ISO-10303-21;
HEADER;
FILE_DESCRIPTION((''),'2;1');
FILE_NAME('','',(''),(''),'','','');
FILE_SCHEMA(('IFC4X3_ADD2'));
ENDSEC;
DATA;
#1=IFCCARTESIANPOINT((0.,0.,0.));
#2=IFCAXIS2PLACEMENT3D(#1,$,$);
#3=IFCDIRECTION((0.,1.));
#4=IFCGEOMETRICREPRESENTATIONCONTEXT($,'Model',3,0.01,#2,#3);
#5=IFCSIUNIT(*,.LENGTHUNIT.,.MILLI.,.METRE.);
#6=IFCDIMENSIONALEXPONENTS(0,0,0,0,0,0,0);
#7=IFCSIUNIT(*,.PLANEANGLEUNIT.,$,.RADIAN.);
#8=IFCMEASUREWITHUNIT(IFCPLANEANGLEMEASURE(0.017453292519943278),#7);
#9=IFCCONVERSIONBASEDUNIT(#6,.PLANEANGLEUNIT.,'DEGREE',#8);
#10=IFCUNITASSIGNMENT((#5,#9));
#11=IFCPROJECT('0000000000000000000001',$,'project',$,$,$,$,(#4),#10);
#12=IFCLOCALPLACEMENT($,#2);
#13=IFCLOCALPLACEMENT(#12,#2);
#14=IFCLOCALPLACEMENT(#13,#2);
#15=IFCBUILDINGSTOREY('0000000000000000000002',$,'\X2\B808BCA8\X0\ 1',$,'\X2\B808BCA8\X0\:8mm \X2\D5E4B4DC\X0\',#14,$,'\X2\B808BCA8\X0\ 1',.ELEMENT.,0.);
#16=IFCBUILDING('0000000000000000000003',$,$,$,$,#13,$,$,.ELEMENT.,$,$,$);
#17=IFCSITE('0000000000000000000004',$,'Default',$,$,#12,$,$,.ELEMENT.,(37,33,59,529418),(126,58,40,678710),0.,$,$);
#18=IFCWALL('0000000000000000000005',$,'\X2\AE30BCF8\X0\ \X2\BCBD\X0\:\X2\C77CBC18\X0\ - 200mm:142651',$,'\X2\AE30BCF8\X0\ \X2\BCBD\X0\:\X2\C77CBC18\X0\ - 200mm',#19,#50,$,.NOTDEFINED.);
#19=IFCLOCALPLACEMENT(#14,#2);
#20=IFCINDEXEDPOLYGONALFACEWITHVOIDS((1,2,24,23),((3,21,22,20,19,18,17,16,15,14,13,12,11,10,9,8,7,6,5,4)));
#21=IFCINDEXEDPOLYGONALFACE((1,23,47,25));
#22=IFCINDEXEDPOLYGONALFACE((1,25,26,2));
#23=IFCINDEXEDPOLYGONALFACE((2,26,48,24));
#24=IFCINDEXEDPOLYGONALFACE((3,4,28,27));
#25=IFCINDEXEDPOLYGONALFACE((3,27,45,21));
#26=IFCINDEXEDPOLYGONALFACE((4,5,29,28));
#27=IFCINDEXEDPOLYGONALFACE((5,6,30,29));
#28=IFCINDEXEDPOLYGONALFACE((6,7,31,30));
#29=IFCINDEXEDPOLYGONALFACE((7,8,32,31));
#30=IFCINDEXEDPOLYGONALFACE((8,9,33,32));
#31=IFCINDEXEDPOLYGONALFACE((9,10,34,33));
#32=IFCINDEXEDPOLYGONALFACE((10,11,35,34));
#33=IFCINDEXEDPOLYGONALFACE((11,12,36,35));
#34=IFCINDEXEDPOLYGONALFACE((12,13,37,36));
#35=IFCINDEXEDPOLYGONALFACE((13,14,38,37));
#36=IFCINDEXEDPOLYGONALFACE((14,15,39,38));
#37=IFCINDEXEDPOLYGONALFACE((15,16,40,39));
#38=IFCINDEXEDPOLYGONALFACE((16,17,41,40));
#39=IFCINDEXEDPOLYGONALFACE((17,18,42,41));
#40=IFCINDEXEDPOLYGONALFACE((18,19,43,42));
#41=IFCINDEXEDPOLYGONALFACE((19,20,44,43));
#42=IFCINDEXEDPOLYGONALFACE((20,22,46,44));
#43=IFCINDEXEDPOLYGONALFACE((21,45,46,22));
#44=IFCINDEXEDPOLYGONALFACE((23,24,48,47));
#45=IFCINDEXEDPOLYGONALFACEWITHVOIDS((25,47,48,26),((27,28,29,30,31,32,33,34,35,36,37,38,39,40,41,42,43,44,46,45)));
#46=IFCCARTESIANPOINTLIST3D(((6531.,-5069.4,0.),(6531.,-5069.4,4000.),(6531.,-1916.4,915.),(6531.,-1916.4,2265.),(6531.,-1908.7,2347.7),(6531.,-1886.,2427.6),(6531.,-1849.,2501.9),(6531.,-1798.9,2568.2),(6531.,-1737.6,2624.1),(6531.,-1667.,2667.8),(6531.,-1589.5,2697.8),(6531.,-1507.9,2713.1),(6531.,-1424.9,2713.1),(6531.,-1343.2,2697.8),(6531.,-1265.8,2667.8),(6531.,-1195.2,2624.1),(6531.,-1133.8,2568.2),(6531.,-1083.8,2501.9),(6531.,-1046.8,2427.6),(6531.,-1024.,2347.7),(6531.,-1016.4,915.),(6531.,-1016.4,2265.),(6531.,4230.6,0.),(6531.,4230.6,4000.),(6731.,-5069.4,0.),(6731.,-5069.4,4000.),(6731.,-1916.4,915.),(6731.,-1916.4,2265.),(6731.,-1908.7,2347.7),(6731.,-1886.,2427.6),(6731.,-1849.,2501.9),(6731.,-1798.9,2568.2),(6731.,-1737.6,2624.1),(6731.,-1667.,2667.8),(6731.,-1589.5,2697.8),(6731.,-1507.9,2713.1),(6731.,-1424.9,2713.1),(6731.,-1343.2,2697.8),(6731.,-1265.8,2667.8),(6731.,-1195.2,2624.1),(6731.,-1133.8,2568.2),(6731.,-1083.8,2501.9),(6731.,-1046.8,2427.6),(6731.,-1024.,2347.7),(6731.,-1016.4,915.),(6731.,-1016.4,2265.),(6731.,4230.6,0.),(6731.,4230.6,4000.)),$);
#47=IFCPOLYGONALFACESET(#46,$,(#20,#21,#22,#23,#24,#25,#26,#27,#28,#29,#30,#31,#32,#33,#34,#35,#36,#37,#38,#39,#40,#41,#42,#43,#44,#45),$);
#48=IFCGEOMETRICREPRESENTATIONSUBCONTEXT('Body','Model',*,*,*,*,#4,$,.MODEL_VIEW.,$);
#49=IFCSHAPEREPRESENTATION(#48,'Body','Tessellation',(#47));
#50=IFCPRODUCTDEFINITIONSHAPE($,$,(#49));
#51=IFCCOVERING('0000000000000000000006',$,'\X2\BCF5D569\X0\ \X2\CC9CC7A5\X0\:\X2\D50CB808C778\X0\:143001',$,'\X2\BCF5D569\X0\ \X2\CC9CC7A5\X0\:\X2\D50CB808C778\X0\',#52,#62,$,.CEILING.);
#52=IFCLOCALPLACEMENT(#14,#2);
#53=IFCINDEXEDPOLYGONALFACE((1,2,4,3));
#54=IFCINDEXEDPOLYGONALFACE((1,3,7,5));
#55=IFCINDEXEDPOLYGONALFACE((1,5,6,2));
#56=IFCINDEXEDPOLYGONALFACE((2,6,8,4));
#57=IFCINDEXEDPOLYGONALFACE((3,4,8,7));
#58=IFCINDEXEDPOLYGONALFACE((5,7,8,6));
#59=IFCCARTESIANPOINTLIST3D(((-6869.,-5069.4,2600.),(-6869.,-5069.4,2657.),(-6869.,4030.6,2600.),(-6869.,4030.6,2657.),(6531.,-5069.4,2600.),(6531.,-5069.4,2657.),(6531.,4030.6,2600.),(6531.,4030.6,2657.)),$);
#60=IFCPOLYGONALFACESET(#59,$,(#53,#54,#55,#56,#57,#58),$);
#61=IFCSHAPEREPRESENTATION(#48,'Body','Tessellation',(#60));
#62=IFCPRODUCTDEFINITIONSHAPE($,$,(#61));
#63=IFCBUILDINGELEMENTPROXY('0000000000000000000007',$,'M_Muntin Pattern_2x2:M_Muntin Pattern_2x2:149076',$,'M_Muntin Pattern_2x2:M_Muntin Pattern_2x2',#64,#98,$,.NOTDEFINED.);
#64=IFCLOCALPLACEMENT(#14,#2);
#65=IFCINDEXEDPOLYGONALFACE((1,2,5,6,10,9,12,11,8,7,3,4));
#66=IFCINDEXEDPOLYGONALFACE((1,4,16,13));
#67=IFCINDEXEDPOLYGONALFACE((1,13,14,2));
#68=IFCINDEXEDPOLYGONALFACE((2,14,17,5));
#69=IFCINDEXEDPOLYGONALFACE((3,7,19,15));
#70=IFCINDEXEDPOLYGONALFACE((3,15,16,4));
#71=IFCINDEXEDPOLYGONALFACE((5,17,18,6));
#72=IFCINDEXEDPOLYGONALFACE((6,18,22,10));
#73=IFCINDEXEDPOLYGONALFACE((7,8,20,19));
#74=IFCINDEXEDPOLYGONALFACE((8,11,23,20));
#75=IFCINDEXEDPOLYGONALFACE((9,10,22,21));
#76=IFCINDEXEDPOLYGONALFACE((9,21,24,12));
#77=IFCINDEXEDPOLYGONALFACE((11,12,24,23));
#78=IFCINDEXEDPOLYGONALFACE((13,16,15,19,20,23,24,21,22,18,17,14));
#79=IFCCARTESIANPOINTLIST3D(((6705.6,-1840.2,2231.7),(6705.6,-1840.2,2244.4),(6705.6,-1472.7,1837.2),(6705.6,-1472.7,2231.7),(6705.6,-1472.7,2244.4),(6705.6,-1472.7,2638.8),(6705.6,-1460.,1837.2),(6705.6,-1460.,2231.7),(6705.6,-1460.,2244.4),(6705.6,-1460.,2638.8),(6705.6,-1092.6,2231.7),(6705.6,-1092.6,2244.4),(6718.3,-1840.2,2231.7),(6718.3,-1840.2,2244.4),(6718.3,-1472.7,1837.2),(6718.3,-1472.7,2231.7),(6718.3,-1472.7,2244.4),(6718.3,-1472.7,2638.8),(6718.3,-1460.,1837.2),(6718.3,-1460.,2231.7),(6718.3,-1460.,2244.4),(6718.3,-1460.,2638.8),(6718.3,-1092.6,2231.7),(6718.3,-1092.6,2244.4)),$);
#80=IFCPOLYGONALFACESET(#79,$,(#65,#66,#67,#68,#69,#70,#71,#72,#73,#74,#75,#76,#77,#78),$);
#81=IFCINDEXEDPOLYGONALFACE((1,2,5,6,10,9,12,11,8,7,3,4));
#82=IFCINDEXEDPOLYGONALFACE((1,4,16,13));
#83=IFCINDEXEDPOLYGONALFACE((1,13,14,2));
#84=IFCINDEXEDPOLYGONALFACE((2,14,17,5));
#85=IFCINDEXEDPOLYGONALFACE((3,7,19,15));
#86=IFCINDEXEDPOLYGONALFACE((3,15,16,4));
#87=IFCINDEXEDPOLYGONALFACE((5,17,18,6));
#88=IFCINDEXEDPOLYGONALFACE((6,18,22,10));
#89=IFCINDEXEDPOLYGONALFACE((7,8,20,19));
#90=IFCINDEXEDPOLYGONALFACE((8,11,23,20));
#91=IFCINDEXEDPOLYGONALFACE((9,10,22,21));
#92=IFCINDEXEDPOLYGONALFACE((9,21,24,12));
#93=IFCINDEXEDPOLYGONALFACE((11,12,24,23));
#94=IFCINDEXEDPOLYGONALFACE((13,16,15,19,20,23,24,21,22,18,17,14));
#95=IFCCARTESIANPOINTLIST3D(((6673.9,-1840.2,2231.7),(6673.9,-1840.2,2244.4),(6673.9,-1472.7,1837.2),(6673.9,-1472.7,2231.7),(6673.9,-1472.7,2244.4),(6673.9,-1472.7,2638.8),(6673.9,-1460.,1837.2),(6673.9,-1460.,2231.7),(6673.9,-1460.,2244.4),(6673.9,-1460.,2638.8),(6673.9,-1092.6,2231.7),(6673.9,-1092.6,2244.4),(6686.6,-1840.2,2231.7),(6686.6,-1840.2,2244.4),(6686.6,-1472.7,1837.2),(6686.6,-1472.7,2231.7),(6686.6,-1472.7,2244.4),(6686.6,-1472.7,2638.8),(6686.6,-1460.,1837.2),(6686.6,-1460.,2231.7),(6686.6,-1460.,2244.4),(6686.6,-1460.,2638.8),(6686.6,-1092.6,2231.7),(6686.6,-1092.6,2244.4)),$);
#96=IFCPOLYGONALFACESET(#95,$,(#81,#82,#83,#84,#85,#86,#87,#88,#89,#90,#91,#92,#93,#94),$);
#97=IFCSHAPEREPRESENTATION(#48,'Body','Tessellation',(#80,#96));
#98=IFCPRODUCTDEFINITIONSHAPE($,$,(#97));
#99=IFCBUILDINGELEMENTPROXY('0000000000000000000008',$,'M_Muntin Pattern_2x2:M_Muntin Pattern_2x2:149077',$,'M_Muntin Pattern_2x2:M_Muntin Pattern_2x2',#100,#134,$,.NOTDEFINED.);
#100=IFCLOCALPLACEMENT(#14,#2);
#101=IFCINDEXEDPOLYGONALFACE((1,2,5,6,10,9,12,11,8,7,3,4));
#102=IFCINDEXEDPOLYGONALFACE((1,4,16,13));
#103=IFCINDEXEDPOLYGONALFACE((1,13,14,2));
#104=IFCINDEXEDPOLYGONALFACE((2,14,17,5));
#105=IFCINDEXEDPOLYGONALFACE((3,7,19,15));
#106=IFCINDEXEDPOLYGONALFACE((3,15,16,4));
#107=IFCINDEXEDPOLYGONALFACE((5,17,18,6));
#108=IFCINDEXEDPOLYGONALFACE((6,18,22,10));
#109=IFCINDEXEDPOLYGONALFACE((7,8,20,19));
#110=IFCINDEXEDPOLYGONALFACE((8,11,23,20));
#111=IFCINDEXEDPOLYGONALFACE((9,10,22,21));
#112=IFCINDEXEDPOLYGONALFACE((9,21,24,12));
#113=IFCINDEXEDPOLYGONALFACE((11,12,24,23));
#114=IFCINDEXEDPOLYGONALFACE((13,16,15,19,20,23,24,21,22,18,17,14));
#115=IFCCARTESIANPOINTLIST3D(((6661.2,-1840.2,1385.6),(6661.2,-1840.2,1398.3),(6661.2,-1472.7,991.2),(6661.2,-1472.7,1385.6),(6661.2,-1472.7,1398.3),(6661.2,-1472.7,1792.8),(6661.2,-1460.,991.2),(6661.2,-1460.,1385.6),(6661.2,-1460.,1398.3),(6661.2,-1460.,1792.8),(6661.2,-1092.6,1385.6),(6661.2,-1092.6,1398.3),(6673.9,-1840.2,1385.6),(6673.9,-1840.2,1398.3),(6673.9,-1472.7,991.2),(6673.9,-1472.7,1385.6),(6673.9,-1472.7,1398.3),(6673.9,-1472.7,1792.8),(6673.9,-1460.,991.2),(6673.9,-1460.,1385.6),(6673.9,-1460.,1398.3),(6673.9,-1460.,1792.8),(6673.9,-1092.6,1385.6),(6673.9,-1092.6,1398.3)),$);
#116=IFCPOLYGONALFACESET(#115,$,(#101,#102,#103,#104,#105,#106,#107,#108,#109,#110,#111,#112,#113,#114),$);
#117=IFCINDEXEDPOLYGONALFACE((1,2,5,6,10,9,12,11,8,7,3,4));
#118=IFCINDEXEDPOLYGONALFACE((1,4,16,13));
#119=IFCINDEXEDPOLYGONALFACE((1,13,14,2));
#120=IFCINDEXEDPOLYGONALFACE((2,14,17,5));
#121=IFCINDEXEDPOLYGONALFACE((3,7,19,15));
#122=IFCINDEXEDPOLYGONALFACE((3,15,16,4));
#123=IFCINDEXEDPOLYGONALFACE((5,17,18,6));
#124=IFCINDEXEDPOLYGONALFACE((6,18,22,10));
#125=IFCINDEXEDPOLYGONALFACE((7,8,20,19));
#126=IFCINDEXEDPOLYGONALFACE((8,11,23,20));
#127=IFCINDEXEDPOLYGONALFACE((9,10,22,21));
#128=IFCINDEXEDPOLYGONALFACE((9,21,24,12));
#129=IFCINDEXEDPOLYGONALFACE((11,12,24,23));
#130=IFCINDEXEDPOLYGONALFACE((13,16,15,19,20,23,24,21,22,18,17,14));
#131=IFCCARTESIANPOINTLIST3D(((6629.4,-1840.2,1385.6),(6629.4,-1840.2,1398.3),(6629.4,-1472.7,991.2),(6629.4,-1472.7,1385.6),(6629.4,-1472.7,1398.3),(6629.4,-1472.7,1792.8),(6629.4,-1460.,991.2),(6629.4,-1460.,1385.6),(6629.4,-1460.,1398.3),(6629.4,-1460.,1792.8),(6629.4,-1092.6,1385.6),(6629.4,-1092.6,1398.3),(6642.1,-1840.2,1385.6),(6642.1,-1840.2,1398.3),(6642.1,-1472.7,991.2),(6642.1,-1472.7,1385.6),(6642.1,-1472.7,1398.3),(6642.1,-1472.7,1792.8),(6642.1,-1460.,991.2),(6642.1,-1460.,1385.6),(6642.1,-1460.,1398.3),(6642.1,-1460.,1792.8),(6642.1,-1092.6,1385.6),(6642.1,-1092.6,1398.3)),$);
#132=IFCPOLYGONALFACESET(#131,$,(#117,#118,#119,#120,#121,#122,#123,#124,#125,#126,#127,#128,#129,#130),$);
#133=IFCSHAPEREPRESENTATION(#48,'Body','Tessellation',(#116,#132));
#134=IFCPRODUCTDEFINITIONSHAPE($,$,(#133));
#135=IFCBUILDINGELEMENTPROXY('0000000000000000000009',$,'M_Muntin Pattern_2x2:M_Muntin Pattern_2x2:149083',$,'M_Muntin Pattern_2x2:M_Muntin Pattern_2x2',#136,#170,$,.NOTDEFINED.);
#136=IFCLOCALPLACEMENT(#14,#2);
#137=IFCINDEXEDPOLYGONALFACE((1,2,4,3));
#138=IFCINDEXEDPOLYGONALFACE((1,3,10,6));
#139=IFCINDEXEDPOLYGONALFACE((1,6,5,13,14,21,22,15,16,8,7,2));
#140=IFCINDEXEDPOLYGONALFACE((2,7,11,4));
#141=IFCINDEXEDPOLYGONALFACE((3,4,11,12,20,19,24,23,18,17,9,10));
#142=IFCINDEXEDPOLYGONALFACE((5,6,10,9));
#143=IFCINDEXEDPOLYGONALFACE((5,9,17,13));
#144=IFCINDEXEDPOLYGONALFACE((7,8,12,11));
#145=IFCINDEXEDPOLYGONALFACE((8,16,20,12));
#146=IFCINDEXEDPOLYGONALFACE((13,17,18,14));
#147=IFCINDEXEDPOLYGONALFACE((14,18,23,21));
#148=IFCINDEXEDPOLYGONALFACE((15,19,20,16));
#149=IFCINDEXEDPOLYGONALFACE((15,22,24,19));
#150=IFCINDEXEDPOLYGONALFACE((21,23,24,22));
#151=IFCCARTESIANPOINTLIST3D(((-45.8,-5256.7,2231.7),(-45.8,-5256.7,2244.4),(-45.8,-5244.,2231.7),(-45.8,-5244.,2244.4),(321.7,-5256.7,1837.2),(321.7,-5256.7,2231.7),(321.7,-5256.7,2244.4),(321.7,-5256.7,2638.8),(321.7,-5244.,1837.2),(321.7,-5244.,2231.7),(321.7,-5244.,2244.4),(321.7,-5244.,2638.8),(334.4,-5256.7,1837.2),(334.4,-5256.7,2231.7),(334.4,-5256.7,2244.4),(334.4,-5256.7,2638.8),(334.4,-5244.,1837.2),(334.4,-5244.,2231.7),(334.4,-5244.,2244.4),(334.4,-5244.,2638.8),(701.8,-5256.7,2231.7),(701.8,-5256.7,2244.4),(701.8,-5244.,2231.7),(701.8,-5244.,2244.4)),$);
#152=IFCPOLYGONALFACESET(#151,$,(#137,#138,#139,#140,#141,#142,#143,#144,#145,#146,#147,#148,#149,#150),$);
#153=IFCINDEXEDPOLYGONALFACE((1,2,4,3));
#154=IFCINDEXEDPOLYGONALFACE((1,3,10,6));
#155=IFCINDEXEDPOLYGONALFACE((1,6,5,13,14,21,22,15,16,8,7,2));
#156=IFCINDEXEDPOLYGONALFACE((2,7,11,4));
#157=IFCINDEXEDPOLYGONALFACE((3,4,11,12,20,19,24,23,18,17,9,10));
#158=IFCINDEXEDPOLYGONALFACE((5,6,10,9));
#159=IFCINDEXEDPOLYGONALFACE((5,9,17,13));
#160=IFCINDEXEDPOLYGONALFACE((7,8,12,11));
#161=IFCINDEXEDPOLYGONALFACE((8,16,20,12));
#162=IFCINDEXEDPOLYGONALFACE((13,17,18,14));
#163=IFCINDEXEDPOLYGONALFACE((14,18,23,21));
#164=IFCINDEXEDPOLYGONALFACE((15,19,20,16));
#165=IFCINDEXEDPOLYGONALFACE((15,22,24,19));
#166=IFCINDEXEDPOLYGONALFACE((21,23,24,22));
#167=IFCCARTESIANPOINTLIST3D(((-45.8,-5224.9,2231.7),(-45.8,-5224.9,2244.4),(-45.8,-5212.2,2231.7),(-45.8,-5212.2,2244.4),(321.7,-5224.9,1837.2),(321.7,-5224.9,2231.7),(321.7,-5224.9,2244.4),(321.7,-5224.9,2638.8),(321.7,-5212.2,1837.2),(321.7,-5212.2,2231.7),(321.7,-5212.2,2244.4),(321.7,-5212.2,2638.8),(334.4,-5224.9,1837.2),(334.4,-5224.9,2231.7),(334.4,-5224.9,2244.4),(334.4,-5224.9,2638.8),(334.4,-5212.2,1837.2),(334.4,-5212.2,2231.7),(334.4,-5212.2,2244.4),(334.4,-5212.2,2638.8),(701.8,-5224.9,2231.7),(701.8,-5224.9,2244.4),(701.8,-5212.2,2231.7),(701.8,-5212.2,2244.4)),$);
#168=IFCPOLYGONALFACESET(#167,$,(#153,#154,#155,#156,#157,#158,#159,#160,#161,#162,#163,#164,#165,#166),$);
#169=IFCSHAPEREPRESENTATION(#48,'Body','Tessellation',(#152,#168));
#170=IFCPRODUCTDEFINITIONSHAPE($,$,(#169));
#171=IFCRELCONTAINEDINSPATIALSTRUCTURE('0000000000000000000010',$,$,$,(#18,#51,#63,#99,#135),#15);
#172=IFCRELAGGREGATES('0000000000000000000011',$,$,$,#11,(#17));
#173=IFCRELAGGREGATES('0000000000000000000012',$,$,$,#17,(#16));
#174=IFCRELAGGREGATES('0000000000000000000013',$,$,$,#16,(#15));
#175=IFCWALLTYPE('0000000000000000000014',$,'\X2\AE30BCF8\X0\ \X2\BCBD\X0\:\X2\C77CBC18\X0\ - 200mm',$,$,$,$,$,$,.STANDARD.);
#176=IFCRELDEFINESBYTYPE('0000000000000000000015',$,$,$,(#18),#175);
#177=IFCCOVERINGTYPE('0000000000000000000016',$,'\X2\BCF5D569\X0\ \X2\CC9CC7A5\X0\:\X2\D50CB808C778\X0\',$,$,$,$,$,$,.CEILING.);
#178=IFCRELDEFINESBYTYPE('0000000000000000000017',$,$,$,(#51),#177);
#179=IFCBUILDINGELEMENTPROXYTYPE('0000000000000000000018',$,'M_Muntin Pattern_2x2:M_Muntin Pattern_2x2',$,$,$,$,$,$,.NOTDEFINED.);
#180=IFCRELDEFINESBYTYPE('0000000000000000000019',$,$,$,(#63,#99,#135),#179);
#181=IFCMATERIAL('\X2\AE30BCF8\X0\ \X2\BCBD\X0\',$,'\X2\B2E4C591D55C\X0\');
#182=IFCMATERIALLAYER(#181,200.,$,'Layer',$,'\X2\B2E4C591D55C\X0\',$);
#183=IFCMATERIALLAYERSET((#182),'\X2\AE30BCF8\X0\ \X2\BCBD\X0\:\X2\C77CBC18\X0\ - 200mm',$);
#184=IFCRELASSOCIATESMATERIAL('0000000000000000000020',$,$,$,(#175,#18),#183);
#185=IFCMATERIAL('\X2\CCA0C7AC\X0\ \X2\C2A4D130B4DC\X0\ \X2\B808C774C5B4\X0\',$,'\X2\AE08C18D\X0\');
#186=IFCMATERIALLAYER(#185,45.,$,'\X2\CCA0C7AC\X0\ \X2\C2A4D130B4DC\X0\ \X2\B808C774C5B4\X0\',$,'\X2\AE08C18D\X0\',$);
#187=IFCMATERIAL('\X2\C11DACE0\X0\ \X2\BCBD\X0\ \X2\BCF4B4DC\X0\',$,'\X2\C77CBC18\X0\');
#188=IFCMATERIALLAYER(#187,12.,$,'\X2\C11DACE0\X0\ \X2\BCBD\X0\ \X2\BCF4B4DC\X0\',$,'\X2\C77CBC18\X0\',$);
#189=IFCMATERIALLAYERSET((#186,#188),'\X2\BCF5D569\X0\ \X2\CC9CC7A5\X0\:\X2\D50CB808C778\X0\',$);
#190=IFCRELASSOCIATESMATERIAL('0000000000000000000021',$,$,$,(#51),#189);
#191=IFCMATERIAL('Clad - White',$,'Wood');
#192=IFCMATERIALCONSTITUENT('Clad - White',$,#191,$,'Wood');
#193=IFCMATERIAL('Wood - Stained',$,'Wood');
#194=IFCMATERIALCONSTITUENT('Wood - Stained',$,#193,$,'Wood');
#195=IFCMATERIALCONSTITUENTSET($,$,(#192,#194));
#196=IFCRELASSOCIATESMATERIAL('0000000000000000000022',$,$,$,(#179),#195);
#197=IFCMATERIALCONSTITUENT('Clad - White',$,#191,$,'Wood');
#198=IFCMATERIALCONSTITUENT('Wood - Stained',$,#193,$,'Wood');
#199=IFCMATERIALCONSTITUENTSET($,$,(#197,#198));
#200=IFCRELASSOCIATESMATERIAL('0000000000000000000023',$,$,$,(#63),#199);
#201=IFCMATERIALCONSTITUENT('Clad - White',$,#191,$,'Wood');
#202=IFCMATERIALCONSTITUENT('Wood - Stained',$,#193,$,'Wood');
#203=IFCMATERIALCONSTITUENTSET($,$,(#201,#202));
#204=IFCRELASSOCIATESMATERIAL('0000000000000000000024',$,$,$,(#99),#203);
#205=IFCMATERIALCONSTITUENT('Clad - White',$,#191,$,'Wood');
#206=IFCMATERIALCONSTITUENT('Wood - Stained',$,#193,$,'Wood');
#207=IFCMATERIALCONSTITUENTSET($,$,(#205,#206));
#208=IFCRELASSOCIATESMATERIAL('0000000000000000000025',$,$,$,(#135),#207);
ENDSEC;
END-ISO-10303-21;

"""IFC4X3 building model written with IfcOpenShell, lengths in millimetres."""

from ifc_helpers import new_model, entity, si_unit, converted_unit, direction, frame, frame_2d, origin, origin_2d_with_axis, place, context, subcontext, project, spatial, polyline, circle_curve, parameter, trimmed, segment, composite_curve, rectangle, outline, extrude, source, transform, mapped, material, layer, layer_set, layer_usage, constituent, constituent_set, type_object, type_shapes, element, save


model = new_model("IFC4X3")

# Units and contexts
model_context = context("Model", 3, precision=0.01, world=origin(), true_north=direction((0.0, 1.0)))
body_context = subcontext(model_context, "Body", "Model", "MODEL_VIEW")
ifc_project = project(units=[si_unit("LENGTHUNIT", "METRE", prefix="MILLI"), converted_unit("PLANEANGLEUNIT", "DEGREE", entity("IfcPlaneAngleMeasure", 0.017453292519943278), si_unit("PLANEANGLEUNIT", "RADIAN"), dimensions=[0, 0, 0, 0, 0, 0, 0])], contexts=[model_context])

# Site, building, storey
site_placement = place(None, origin())
site = spatial("IfcSite", under=ifc_project, at=site_placement, Name="Default", CompositionType="ELEMENT", RefLatitude=(37, 33, 59, 529418), RefLongitude=(126, 58, 40, 678710), RefElevation=0.0)
building_placement = place(site_placement, origin())
building = spatial("IfcBuilding", under=site, at=building_placement, CompositionType="ELEMENT")
storey_placement = place(building_placement, origin())
storey = spatial("IfcBuildingStorey", under=building, at=storey_placement, Name="레벨 1", ObjectType="레벨:8mm 헤드", LongName="레벨 1", CompositionType="ELEMENT", Elevation=0.0)

# Shared definitions
ifc_material_1 = material(Name="기본 벽", Category="다양한")
ifc_layer_1 = layer(ifc_material_1, 200.0, Name="Layer", Category="다양한")
ifc_layer_set_1 = layer_set([ifc_layer_1], Name="기본 벽:일반 - 200mm")
wall_type = type_object("IfcWallType", Name="기본 벽:일반 - 200mm", PredefinedType="STANDARD", material=ifc_layer_set_1)

# Wall, opening
wall_1_placement = place(storey_placement, frame((6631.0, 4230.6, 0.0), z_axis=(0.0, 0.0, 1.0), x_axis=(0.0, -1.0, 0.0)))
wall_1 = element("IfcWall", 1, at=wall_1_placement, inside=storey, type_object=wall_type, material=ifc_layer_set_1, Name="기본 벽:일반 - 200mm:142651", ObjectType="기본 벽:일반 - 200mm", PredefinedType="NOTDEFINED", context=body_context, shape_type="SweptSolid", body=[
    extrude(rectangle(XDim=9300.0, YDim=200.0, at=frame_2d((4650.0, 0.0), x_axis=(-1.0, 0.0))), origin(), (0.0, 0.0, 1.0), 4000.0),
])
opening_1_placement = place(wall_1_placement, frame((5247.0, -100.0, 915.0)))
element("IfcOpeningElement", 2, at=opening_1_placement, cuts=wall_1, PredefinedType="OPENING", context=body_context, shape_type="SweptSolid", body=[
    extrude(outline(composite_curve([segment(polyline([(1350.0, 900.0), (0.0, 900.0)]), True, "CONTINUOUS"), segment(polyline([(0.0, 900.0), (0.0, 0.0)]), True, "CONTINUOUS"), segment(polyline([(0.0, 0.0), (1350.0, 0.0)]), True, "CONTINUOUS"), segment(trimmed(circle_curve(frame_2d((1350.0, 450.0), x_axis=(0.0, 1.0)), 450.0), [parameter(180.0)], [parameter(0.0)], True, "PARAMETER"), True, "CONTINUOUS")], self_intersect=False)), frame((0.0, 0.0, 0.0), z_axis=(0.0, 1.0, 0.0), x_axis=(0.0, 0.0, 1.0)), (0.0, 0.0, 1.0), 200.0),
])

# Covering
ifc_material_2 = material(Name="철재 스터드 레이어", Category="금속")
ifc_layer_2 = layer(ifc_material_2, 45.0, Name="철재 스터드 레이어", Category="금속")
ifc_material_3 = material(Name="석고 벽 보드", Category="일반")
ifc_layer_3 = layer(ifc_material_3, 12.0, Name="석고 벽 보드", Category="일반")
ifc_layer_set_2 = layer_set([ifc_layer_2, ifc_layer_3], Name="복합 천장:플레인")
ifc_layer_usage_1 = layer_usage(ifc_layer_set_2, "AXIS3", "NEGATIVE", 57.0)
covering_type = type_object("IfcCoveringType", Name="복합 천장:플레인", PredefinedType="CEILING")
covering_placement = place(storey_placement, frame((-6869.0, -5069.4, 2600.0)))
element("IfcCovering", 3, at=covering_placement, inside=storey, type_object=covering_type, material=ifc_layer_usage_1, Name="복합 천장:플레인:143001", ObjectType="복합 천장:플레인", PredefinedType="CEILING", context=body_context, shape_type="SweptSolid", body=[
    extrude(rectangle(XDim=9100.0, YDim=13400.0, at=origin_2d_with_axis()), frame((6700.0, 4550.0, 0.0), z_axis=(0.0, 0.0, 1.0), x_axis=(0.0, -1.0, 0.0)), (0.0, 0.0, 1.0), 57.0),
])

# Building element proxies
ifc_material_4 = material(Name="Clad - White", Category="Wood")
ifc_constituent_1 = constituent(ifc_material_4, Name="Clad - White", Category="Wood")
ifc_material_5 = material(Name="Wood - Stained", Category="Wood")
ifc_constituent_2 = constituent(ifc_material_5, Name="Wood - Stained", Category="Wood")
ifc_constituent_set_1 = constituent_set(constituents=[ifc_constituent_1, ifc_constituent_2])
ifc_constituent_3 = constituent(ifc_material_4, Name="Clad - White", Category="Wood")
ifc_constituent_4 = constituent(ifc_material_5, Name="Wood - Stained", Category="Wood")
ifc_constituent_set_2 = constituent_set(constituents=[ifc_constituent_3, ifc_constituent_4])
building_element_proxy_type_1 = type_object("IfcBuildingElementProxyType", Name="M_Muntin Pattern_2x2:M_Muntin Pattern_2x2", PredefinedType="NOTDEFINED", material=ifc_constituent_set_2)
shared_shape_1 = source(origin(), body_context, "Body", "SweptSolid", [
    extrude(outline(polyline([(6.4, -6.4), (400.8, -6.4), (400.8, 6.3), (6.4, 6.3), (6.4, 373.8), (-6.3, 373.8), (-6.3, 6.3), (-400.8, 6.3), (-400.8, -6.4), (-6.3, -6.4), (-6.3, -373.8), (6.4, -373.8), (6.4, -6.4)])), frame((0.0, 9.5, 400.8), z_axis=(0.0, 1.0, 0.0), x_axis=(0.0, 0.0, 1.0)), (0.0, 0.0, 1.0), 12.7),
    extrude(outline(polyline([(6.4, -6.4), (400.8, -6.4), (400.8, 6.3), (6.4, 6.3), (6.4, 373.8), (-6.3, 373.8), (-6.3, 6.3), (-400.8, 6.3), (-400.8, -6.4), (-6.3, -6.4), (-6.3, -373.8), (6.4, -373.8), (6.4, -6.4)])), frame((0.0, -22.2, 400.8), z_axis=(0.0, 1.0, 0.0), x_axis=(0.0, 0.0, 1.0)), (0.0, 0.0, 1.0), 12.7),
])
type_shapes(building_element_proxy_type_1, [shared_shape_1])
proxy_1_placement = place(storey_placement, frame((6696.1, -1466.4, 1837.2), z_axis=(0.0, 0.0, 1.0), x_axis=(0.0, -1.0, 0.0)))
element("IfcBuildingElementProxy", 4, at=proxy_1_placement, inside=storey, type_object=building_element_proxy_type_1, material=ifc_constituent_set_1, Name="M_Muntin Pattern_2x2:M_Muntin Pattern_2x2:149076", ObjectType="M_Muntin Pattern_2x2:M_Muntin Pattern_2x2", PredefinedType="NOTDEFINED", context=body_context, shape_type="MappedRepresentation", body=[
    mapped(shared_shape_1, transform((0.0, 0.0, 0.0), scale=1.0)),
])
ifc_constituent_5 = constituent(ifc_material_4, Name="Clad - White", Category="Wood")
ifc_constituent_6 = constituent(ifc_material_5, Name="Wood - Stained", Category="Wood")
ifc_constituent_set_3 = constituent_set(constituents=[ifc_constituent_5, ifc_constituent_6])
proxy_2_placement = place(storey_placement, frame((6651.7, -1466.4, 991.2), z_axis=(0.0, 0.0, 1.0), x_axis=(0.0, -1.0, 0.0)))
element("IfcBuildingElementProxy", 5, at=proxy_2_placement, inside=storey, type_object=building_element_proxy_type_1, material=ifc_constituent_set_3, Name="M_Muntin Pattern_2x2:M_Muntin Pattern_2x2:149077", ObjectType="M_Muntin Pattern_2x2:M_Muntin Pattern_2x2", PredefinedType="NOTDEFINED", context=body_context, shape_type="MappedRepresentation", body=[
    mapped(shared_shape_1, transform((0.0, 0.0, 0.0), scale=1.0)),
])
ifc_constituent_7 = constituent(ifc_material_4, Name="Clad - White", Category="Wood")
ifc_constituent_8 = constituent(ifc_material_5, Name="Wood - Stained", Category="Wood")
ifc_constituent_set_4 = constituent_set(constituents=[ifc_constituent_7, ifc_constituent_8])
proxy_3_placement = place(storey_placement, frame((328.0, -5234.4, 1837.2), z_axis=(0.0, 0.0, 1.0), x_axis=(-1.0, 0.0, 0.0)))
element("IfcBuildingElementProxy", 6, at=proxy_3_placement, inside=storey, type_object=building_element_proxy_type_1, material=ifc_constituent_set_4, Name="M_Muntin Pattern_2x2:M_Muntin Pattern_2x2:149083", ObjectType="M_Muntin Pattern_2x2:M_Muntin Pattern_2x2", PredefinedType="NOTDEFINED", context=body_context, shape_type="MappedRepresentation", body=[
    mapped(shared_shape_1, transform((0.0, 0.0, 0.0), scale=1.0)),
])

save(model, "model.ifc")
